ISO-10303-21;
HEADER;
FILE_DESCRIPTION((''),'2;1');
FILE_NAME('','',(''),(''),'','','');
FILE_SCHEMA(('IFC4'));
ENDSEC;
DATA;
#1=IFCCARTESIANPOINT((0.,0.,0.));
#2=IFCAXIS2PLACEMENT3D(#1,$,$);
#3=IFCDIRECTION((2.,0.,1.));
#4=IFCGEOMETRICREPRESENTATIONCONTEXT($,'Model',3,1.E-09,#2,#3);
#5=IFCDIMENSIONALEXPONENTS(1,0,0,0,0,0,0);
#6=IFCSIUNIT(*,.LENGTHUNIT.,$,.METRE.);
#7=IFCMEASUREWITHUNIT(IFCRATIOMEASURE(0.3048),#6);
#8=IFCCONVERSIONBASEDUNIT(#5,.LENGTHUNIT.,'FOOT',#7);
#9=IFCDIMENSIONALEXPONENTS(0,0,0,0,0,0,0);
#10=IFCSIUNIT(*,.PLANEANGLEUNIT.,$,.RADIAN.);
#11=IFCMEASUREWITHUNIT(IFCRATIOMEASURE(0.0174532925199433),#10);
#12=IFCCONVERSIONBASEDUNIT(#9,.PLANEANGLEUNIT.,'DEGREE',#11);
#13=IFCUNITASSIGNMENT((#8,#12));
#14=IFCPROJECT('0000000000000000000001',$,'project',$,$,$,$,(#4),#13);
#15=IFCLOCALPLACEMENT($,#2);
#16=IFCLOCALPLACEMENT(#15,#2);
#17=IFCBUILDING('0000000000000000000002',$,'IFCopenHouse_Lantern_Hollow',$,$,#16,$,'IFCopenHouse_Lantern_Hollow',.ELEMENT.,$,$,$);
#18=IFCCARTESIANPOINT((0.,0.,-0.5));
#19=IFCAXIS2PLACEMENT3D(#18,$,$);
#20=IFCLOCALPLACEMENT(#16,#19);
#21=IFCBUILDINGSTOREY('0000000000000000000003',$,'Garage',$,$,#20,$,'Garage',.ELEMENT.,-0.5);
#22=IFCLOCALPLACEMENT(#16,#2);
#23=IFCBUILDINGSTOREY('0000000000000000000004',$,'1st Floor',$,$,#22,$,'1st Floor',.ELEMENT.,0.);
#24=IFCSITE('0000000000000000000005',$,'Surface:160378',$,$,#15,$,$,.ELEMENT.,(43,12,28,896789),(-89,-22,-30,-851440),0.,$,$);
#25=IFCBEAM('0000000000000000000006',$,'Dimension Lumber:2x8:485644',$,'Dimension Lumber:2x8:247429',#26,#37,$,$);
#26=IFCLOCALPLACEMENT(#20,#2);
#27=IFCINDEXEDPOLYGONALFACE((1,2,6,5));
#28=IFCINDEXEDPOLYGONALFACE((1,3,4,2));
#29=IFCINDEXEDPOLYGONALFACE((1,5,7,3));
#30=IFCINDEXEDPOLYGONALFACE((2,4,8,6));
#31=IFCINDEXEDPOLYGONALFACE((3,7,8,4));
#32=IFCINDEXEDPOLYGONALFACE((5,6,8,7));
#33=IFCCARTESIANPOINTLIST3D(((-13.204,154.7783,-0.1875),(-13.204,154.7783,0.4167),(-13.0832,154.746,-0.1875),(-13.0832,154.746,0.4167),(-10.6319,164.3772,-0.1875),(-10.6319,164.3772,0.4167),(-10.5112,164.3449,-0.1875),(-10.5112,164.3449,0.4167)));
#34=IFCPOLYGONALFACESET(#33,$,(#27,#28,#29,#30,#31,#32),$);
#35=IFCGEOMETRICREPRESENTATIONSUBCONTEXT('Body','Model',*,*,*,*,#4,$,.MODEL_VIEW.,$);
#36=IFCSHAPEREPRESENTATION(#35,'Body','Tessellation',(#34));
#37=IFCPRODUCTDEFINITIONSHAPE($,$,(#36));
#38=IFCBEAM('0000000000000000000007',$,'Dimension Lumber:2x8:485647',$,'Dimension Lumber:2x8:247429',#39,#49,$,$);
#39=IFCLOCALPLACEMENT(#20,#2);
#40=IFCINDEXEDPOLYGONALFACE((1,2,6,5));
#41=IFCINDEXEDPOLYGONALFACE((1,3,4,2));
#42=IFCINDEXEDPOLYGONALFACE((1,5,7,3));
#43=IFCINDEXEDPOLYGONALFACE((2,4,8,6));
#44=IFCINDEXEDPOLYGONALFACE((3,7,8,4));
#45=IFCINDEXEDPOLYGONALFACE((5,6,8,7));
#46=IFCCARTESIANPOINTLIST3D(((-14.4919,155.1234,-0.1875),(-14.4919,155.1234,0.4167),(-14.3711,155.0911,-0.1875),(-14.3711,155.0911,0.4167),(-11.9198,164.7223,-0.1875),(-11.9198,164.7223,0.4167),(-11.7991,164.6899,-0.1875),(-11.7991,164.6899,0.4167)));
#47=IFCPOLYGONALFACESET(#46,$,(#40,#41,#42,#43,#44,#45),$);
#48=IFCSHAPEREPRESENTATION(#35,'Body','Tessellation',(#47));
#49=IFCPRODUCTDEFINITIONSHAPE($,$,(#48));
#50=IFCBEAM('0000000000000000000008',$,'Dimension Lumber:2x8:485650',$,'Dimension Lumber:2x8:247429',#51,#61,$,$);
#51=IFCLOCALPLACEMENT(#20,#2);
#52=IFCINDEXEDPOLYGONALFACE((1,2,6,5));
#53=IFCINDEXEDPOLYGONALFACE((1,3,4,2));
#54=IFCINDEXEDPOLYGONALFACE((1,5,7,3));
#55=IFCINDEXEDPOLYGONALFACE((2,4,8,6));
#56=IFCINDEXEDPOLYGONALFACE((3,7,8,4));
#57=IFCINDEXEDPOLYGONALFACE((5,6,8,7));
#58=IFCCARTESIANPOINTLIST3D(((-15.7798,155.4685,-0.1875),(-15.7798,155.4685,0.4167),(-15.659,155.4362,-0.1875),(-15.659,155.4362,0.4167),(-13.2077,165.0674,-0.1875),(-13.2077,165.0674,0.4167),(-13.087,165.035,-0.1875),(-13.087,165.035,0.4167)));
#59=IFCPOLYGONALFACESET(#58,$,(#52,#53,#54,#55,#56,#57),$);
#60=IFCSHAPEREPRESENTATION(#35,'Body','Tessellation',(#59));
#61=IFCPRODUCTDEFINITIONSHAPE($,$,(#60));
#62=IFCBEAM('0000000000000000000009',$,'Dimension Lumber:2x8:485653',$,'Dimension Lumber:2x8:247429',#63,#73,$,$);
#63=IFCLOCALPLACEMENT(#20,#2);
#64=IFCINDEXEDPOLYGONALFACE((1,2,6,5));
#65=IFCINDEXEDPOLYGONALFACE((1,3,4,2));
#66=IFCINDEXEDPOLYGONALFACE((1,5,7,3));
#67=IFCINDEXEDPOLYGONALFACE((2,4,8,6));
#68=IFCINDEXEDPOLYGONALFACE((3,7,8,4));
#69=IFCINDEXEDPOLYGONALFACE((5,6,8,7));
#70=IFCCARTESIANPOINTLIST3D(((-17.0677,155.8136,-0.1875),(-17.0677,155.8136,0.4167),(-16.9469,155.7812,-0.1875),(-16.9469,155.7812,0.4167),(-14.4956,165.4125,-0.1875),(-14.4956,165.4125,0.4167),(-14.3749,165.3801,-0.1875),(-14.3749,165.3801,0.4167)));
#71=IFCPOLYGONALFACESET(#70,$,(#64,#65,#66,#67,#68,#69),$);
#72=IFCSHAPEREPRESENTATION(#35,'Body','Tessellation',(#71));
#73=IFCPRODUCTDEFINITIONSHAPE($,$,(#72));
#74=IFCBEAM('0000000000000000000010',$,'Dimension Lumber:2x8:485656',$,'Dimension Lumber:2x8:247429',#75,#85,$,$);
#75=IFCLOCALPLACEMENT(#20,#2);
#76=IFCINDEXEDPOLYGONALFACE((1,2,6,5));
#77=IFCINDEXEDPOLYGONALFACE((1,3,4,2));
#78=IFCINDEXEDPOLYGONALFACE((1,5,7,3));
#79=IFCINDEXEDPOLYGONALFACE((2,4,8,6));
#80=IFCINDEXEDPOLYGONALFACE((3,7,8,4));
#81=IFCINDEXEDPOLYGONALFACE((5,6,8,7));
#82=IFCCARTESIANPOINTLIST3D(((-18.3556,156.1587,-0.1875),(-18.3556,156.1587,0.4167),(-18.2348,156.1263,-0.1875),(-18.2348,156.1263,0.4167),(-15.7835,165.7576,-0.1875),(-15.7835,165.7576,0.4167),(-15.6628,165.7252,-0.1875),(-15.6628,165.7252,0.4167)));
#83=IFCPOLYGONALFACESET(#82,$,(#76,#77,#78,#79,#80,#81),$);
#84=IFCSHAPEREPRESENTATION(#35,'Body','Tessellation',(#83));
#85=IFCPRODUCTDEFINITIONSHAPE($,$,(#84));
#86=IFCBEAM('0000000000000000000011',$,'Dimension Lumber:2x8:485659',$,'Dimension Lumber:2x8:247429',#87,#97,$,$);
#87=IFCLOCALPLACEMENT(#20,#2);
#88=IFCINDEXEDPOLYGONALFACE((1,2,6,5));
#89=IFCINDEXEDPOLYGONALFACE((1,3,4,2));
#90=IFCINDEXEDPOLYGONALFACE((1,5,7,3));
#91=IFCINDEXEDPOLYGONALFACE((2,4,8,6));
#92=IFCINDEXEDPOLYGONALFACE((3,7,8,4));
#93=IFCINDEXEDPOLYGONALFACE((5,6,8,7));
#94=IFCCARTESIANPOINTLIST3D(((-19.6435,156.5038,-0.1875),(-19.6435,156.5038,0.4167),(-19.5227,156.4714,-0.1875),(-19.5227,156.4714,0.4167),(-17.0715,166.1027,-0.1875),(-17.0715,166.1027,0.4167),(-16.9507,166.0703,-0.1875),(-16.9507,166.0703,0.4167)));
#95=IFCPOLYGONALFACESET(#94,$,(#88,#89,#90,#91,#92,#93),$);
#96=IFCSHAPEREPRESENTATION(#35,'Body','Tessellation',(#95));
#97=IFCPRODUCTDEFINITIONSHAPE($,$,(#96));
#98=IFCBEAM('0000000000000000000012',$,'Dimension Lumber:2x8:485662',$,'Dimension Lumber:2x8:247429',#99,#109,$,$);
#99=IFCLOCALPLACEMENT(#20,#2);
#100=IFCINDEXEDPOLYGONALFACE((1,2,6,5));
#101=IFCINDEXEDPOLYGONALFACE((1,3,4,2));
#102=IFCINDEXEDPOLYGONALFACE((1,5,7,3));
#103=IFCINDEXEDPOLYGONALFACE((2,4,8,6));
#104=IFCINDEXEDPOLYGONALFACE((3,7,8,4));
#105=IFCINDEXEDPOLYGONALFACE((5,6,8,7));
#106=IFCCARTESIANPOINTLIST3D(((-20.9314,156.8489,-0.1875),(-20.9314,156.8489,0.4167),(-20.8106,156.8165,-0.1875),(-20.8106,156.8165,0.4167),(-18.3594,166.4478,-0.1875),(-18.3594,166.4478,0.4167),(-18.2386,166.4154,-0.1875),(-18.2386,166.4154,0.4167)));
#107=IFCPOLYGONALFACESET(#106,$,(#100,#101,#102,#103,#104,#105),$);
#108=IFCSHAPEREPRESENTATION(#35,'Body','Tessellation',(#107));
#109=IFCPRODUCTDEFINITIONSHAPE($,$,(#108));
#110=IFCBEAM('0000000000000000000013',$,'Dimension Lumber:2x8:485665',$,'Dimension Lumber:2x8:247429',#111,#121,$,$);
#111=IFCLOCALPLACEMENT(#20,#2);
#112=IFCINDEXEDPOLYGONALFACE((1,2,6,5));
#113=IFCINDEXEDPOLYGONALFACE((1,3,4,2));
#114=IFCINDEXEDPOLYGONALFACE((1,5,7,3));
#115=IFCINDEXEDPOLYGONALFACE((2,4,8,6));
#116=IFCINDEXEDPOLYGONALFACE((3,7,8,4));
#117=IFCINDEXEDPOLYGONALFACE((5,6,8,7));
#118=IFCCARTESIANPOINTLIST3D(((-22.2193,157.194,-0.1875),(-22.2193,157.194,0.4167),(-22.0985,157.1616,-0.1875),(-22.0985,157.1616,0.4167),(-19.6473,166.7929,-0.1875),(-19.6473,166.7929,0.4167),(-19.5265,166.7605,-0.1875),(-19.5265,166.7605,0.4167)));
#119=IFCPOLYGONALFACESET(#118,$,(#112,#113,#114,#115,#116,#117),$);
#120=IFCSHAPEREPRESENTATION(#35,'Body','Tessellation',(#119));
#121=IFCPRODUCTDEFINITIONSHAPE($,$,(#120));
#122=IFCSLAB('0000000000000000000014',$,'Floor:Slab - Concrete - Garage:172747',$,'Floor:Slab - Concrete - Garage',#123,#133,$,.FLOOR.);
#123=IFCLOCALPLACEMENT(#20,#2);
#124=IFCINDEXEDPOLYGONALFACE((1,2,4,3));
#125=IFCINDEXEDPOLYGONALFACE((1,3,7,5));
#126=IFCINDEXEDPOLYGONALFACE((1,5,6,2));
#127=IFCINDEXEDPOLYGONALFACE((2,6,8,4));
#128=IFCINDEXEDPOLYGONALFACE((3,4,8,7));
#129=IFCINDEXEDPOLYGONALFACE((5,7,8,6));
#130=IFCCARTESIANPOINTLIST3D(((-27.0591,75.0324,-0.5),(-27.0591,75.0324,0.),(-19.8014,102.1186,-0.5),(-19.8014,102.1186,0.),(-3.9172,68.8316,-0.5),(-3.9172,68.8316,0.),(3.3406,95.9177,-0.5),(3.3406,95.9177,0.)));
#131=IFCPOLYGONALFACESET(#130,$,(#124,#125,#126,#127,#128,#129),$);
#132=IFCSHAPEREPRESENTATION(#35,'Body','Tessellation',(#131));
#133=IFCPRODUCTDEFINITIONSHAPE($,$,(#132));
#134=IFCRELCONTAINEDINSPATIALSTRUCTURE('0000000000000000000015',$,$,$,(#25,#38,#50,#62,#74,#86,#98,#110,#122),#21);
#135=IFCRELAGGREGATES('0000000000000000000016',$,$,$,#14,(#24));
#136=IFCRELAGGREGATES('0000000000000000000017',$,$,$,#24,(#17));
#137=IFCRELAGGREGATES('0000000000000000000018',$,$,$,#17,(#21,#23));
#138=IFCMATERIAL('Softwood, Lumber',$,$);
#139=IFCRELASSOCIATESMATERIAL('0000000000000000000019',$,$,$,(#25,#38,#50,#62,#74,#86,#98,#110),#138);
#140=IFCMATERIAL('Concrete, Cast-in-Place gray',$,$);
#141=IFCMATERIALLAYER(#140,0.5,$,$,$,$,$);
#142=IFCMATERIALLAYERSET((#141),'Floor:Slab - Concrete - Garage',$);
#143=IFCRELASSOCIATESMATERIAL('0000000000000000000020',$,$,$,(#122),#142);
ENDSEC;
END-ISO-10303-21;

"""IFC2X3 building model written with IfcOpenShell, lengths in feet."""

from ifc_helpers import new_model, entity, si_unit, converted_unit, direction, frame, frame_2d, origin, origin_2d_with_axis, place, context, subcontext, project, spatial, rectangle, extrude, material, layer, layer_set, layer_usage, element, save


model = new_model("IFC2X3")

# Units and contexts
model_context = context("Model", 3, precision=1e-09, world=origin(), true_north=direction((2.0, 0.0, 1.0)))
body_context = subcontext(model_context, "Body", "Model", "MODEL_VIEW")
ifc_project = project(units=[converted_unit("LENGTHUNIT", "FOOT", entity("IfcRatioMeasure", 0.3048), si_unit("LENGTHUNIT", "METRE"), dimensions=[1, 0, 0, 0, 0, 0, 0]), converted_unit("PLANEANGLEUNIT", "DEGREE", entity("IfcRatioMeasure", 0.0174532925199433), si_unit("PLANEANGLEUNIT", "RADIAN"), dimensions=[0, 0, 0, 0, 0, 0, 0])], contexts=[model_context])

# Site, building, storey
site_placement = place(None, origin())
site = spatial("IfcSite", under=ifc_project, at=site_placement, Name="Surface:160378", CompositionType="ELEMENT", RefLatitude=(43, 12, 28, 896789), RefLongitude=(-89, -22, -30, -851440), RefElevation=0.0)
building_placement = place(site_placement, origin())
building = spatial("IfcBuilding", under=site, at=building_placement, Name="IFCopenHouse_Lantern_Hollow", LongName="IFCopenHouse_Lantern_Hollow", CompositionType="ELEMENT")
storey_1_placement = place(building_placement, frame((0.0, 0.0, -0.5)))
storey_1 = spatial("IfcBuildingStorey", under=building, at=storey_1_placement, Name="Garage", LongName="Garage", CompositionType="ELEMENT", Elevation=-0.5)

# Beams
ifc_material_1 = material(Name="Softwood, Lumber")
beam_1_placement = place(storey_1_placement, frame((-10.5716, 164.361, 0.5), z_axis=(0.0, 0.0, 1.0), x_axis=(-0.258819, -0.965926, 0.0)))
element("IfcBeam", 1, at=beam_1_placement, inside=storey_1, material=ifc_material_1, Name="Dimension Lumber:2x8:485644", ObjectType="Dimension Lumber:2x8:247429", context=body_context, shape_type="SweptSolid", body=[
    extrude(rectangle(XDim=0.6042, YDim=0.125, at=origin_2d_with_axis()), frame((0.0, 0.0, -0.3854), z_axis=(1.0, 0.0, 0.0), x_axis=(0.0, 0.0, -1.0)), (0.0, 0.0, 1.0), 9.9375),
])
beam_2_placement = place(storey_1_placement, frame((-11.8595, 164.7061, 0.5), z_axis=(0.0, 0.0, 1.0), x_axis=(-0.258819, -0.965926, 0.0)))
element("IfcBeam", 2, at=beam_2_placement, inside=storey_1, material=ifc_material_1, Name="Dimension Lumber:2x8:485647", ObjectType="Dimension Lumber:2x8:247429", context=body_context, shape_type="SweptSolid", body=[
    extrude(rectangle(XDim=0.6042, YDim=0.125, at=frame_2d((0.0, 0.0), x_axis=(1.0, 0.0))), frame((0.0, 0.0, -0.3854), z_axis=(1.0, 0.0, 0.0), x_axis=(0.0, 0.0, -1.0)), (0.0, 0.0, 1.0), 9.9375),
])
beam_3_placement = place(storey_1_placement, frame((-13.1474, 165.0512, 0.5), z_axis=(0.0, 0.0, 1.0), x_axis=(-0.258819, -0.965926, 0.0)))
element("IfcBeam", 3, at=beam_3_placement, inside=storey_1, material=ifc_material_1, Name="Dimension Lumber:2x8:485650", ObjectType="Dimension Lumber:2x8:247429", context=body_context, shape_type="SweptSolid", body=[
    extrude(rectangle(XDim=0.6042, YDim=0.125, at=frame_2d((0.0, 0.0), x_axis=(1.0, 0.0))), frame((0.0, 0.0, -0.3854), z_axis=(1.0, 0.0, 0.0), x_axis=(0.0, 0.0, -1.0)), (0.0, 0.0, 1.0), 9.9375),
])
beam_4_placement = place(storey_1_placement, frame((-14.4353, 165.3963, 0.5), z_axis=(0.0, 0.0, 1.0), x_axis=(-0.258819, -0.965926, 0.0)))
element("IfcBeam", 4, at=beam_4_placement, inside=storey_1, material=ifc_material_1, Name="Dimension Lumber:2x8:485653", ObjectType="Dimension Lumber:2x8:247429", context=body_context, shape_type="SweptSolid", body=[
    extrude(rectangle(XDim=0.6042, YDim=0.125, at=origin_2d_with_axis()), frame((0.0, 0.0, -0.3854), z_axis=(1.0, 0.0, 0.0), x_axis=(0.0, 0.0, -1.0)), (0.0, 0.0, 1.0), 9.9375),
])
beam_5_placement = place(storey_1_placement, frame((-15.7232, 165.7414, 0.5), z_axis=(0.0, 0.0, 1.0), x_axis=(-0.258819, -0.965926, 0.0)))
element("IfcBeam", 5, at=beam_5_placement, inside=storey_1, material=ifc_material_1, Name="Dimension Lumber:2x8:485656", ObjectType="Dimension Lumber:2x8:247429", context=body_context, shape_type="SweptSolid", body=[
    extrude(rectangle(XDim=0.6042, YDim=0.125, at=frame_2d((0.0, 0.0), x_axis=(1.0, 0.0))), frame((0.0, 0.0, -0.3854), z_axis=(1.0, 0.0, 0.0), x_axis=(0.0, 0.0, -1.0)), (0.0, 0.0, 1.0), 9.9375),
])
for number, where, z_axis, x_axis, name in (
    (6, (-17.0111, 166.0865, 0.5), (0.0, 0.0, 1.0), (-0.258819, -0.965926, 0.0), "Dimension Lumber:2x8:485659"),
    (7, (-18.299, 166.4316, 0.5), (0.0, 0.0, 1.0), (-0.258819, -0.965926, 0.0), "Dimension Lumber:2x8:485662"),
):
    element("IfcBeam", number, at=place(storey_1_placement, frame(where, z_axis=z_axis, x_axis=x_axis)), inside=storey_1, material=ifc_material_1, Name=name, ObjectType="Dimension Lumber:2x8:247429", context=body_context, shape_type="SweptSolid", body=[
        extrude(rectangle(XDim=0.6042, YDim=0.125, at=frame_2d((0.0, 0.0), x_axis=(1.0, 0.0))), frame((0.0, 0.0, -0.3854), z_axis=(1.0, 0.0, 0.0), x_axis=(0.0, 0.0, -1.0)), (0.0, 0.0, 1.0), 9.9375),
    ])
beam_6_placement = place(storey_1_placement, frame((-19.5869, 166.7767, 0.5), z_axis=(0.0, 0.0, 1.0), x_axis=(-0.258819, -0.965926, 0.0)))
element("IfcBeam", 8, at=beam_6_placement, inside=storey_1, material=ifc_material_1, Name="Dimension Lumber:2x8:485665", ObjectType="Dimension Lumber:2x8:247429", context=body_context, shape_type="SweptSolid", body=[
    extrude(rectangle(XDim=0.6042, YDim=0.125, at=frame_2d((0.0, 0.0), x_axis=(1.0, 0.0))), frame((0.0, 0.0, -0.3854), z_axis=(1.0, 0.0, 0.0), x_axis=(0.0, 0.0, -1.0)), (0.0, 0.0, 1.0), 9.9375),
])

# Slab
ifc_material_2 = material(Name="Concrete, Cast-in-Place gray")
ifc_layer_1 = layer(ifc_material_2, 0.5)
ifc_layer_set_1 = layer_set([ifc_layer_1], Name="Floor:Slab - Concrete - Garage")
ifc_layer_usage_1 = layer_usage(ifc_layer_set_1, "AXIS3", "POSITIVE", 0.0)
slab_1_placement = place(storey_1_placement, origin())
element("IfcSlab", 9, at=slab_1_placement, inside=storey_1, material=ifc_layer_usage_1, Name="Floor:Slab - Concrete - Garage:172747", ObjectType="Floor:Slab - Concrete - Garage", PredefinedType="FLOOR", context=body_context, shape_type="SweptSolid", body=[
    extrude(rectangle(XDim=28.0417, YDim=23.9583, at=frame_2d((0.0, 0.0), x_axis=(1.0, 0.0))), frame((-11.8593, 85.4751, 0.0), z_axis=(0.0, 0.0, -1.0), x_axis=(-0.258819, -0.965926, 0.0)), (0.0, 0.0, 1.0), 0.5),
])

# Shared definitions
storey_2_placement = place(building_placement, origin())
storey_2 = spatial("IfcBuildingStorey", under=building, at=storey_2_placement, Name="1st Floor", LongName="1st Floor", CompositionType="ELEMENT", Elevation=0.0)

save(model, "model.ifc")
